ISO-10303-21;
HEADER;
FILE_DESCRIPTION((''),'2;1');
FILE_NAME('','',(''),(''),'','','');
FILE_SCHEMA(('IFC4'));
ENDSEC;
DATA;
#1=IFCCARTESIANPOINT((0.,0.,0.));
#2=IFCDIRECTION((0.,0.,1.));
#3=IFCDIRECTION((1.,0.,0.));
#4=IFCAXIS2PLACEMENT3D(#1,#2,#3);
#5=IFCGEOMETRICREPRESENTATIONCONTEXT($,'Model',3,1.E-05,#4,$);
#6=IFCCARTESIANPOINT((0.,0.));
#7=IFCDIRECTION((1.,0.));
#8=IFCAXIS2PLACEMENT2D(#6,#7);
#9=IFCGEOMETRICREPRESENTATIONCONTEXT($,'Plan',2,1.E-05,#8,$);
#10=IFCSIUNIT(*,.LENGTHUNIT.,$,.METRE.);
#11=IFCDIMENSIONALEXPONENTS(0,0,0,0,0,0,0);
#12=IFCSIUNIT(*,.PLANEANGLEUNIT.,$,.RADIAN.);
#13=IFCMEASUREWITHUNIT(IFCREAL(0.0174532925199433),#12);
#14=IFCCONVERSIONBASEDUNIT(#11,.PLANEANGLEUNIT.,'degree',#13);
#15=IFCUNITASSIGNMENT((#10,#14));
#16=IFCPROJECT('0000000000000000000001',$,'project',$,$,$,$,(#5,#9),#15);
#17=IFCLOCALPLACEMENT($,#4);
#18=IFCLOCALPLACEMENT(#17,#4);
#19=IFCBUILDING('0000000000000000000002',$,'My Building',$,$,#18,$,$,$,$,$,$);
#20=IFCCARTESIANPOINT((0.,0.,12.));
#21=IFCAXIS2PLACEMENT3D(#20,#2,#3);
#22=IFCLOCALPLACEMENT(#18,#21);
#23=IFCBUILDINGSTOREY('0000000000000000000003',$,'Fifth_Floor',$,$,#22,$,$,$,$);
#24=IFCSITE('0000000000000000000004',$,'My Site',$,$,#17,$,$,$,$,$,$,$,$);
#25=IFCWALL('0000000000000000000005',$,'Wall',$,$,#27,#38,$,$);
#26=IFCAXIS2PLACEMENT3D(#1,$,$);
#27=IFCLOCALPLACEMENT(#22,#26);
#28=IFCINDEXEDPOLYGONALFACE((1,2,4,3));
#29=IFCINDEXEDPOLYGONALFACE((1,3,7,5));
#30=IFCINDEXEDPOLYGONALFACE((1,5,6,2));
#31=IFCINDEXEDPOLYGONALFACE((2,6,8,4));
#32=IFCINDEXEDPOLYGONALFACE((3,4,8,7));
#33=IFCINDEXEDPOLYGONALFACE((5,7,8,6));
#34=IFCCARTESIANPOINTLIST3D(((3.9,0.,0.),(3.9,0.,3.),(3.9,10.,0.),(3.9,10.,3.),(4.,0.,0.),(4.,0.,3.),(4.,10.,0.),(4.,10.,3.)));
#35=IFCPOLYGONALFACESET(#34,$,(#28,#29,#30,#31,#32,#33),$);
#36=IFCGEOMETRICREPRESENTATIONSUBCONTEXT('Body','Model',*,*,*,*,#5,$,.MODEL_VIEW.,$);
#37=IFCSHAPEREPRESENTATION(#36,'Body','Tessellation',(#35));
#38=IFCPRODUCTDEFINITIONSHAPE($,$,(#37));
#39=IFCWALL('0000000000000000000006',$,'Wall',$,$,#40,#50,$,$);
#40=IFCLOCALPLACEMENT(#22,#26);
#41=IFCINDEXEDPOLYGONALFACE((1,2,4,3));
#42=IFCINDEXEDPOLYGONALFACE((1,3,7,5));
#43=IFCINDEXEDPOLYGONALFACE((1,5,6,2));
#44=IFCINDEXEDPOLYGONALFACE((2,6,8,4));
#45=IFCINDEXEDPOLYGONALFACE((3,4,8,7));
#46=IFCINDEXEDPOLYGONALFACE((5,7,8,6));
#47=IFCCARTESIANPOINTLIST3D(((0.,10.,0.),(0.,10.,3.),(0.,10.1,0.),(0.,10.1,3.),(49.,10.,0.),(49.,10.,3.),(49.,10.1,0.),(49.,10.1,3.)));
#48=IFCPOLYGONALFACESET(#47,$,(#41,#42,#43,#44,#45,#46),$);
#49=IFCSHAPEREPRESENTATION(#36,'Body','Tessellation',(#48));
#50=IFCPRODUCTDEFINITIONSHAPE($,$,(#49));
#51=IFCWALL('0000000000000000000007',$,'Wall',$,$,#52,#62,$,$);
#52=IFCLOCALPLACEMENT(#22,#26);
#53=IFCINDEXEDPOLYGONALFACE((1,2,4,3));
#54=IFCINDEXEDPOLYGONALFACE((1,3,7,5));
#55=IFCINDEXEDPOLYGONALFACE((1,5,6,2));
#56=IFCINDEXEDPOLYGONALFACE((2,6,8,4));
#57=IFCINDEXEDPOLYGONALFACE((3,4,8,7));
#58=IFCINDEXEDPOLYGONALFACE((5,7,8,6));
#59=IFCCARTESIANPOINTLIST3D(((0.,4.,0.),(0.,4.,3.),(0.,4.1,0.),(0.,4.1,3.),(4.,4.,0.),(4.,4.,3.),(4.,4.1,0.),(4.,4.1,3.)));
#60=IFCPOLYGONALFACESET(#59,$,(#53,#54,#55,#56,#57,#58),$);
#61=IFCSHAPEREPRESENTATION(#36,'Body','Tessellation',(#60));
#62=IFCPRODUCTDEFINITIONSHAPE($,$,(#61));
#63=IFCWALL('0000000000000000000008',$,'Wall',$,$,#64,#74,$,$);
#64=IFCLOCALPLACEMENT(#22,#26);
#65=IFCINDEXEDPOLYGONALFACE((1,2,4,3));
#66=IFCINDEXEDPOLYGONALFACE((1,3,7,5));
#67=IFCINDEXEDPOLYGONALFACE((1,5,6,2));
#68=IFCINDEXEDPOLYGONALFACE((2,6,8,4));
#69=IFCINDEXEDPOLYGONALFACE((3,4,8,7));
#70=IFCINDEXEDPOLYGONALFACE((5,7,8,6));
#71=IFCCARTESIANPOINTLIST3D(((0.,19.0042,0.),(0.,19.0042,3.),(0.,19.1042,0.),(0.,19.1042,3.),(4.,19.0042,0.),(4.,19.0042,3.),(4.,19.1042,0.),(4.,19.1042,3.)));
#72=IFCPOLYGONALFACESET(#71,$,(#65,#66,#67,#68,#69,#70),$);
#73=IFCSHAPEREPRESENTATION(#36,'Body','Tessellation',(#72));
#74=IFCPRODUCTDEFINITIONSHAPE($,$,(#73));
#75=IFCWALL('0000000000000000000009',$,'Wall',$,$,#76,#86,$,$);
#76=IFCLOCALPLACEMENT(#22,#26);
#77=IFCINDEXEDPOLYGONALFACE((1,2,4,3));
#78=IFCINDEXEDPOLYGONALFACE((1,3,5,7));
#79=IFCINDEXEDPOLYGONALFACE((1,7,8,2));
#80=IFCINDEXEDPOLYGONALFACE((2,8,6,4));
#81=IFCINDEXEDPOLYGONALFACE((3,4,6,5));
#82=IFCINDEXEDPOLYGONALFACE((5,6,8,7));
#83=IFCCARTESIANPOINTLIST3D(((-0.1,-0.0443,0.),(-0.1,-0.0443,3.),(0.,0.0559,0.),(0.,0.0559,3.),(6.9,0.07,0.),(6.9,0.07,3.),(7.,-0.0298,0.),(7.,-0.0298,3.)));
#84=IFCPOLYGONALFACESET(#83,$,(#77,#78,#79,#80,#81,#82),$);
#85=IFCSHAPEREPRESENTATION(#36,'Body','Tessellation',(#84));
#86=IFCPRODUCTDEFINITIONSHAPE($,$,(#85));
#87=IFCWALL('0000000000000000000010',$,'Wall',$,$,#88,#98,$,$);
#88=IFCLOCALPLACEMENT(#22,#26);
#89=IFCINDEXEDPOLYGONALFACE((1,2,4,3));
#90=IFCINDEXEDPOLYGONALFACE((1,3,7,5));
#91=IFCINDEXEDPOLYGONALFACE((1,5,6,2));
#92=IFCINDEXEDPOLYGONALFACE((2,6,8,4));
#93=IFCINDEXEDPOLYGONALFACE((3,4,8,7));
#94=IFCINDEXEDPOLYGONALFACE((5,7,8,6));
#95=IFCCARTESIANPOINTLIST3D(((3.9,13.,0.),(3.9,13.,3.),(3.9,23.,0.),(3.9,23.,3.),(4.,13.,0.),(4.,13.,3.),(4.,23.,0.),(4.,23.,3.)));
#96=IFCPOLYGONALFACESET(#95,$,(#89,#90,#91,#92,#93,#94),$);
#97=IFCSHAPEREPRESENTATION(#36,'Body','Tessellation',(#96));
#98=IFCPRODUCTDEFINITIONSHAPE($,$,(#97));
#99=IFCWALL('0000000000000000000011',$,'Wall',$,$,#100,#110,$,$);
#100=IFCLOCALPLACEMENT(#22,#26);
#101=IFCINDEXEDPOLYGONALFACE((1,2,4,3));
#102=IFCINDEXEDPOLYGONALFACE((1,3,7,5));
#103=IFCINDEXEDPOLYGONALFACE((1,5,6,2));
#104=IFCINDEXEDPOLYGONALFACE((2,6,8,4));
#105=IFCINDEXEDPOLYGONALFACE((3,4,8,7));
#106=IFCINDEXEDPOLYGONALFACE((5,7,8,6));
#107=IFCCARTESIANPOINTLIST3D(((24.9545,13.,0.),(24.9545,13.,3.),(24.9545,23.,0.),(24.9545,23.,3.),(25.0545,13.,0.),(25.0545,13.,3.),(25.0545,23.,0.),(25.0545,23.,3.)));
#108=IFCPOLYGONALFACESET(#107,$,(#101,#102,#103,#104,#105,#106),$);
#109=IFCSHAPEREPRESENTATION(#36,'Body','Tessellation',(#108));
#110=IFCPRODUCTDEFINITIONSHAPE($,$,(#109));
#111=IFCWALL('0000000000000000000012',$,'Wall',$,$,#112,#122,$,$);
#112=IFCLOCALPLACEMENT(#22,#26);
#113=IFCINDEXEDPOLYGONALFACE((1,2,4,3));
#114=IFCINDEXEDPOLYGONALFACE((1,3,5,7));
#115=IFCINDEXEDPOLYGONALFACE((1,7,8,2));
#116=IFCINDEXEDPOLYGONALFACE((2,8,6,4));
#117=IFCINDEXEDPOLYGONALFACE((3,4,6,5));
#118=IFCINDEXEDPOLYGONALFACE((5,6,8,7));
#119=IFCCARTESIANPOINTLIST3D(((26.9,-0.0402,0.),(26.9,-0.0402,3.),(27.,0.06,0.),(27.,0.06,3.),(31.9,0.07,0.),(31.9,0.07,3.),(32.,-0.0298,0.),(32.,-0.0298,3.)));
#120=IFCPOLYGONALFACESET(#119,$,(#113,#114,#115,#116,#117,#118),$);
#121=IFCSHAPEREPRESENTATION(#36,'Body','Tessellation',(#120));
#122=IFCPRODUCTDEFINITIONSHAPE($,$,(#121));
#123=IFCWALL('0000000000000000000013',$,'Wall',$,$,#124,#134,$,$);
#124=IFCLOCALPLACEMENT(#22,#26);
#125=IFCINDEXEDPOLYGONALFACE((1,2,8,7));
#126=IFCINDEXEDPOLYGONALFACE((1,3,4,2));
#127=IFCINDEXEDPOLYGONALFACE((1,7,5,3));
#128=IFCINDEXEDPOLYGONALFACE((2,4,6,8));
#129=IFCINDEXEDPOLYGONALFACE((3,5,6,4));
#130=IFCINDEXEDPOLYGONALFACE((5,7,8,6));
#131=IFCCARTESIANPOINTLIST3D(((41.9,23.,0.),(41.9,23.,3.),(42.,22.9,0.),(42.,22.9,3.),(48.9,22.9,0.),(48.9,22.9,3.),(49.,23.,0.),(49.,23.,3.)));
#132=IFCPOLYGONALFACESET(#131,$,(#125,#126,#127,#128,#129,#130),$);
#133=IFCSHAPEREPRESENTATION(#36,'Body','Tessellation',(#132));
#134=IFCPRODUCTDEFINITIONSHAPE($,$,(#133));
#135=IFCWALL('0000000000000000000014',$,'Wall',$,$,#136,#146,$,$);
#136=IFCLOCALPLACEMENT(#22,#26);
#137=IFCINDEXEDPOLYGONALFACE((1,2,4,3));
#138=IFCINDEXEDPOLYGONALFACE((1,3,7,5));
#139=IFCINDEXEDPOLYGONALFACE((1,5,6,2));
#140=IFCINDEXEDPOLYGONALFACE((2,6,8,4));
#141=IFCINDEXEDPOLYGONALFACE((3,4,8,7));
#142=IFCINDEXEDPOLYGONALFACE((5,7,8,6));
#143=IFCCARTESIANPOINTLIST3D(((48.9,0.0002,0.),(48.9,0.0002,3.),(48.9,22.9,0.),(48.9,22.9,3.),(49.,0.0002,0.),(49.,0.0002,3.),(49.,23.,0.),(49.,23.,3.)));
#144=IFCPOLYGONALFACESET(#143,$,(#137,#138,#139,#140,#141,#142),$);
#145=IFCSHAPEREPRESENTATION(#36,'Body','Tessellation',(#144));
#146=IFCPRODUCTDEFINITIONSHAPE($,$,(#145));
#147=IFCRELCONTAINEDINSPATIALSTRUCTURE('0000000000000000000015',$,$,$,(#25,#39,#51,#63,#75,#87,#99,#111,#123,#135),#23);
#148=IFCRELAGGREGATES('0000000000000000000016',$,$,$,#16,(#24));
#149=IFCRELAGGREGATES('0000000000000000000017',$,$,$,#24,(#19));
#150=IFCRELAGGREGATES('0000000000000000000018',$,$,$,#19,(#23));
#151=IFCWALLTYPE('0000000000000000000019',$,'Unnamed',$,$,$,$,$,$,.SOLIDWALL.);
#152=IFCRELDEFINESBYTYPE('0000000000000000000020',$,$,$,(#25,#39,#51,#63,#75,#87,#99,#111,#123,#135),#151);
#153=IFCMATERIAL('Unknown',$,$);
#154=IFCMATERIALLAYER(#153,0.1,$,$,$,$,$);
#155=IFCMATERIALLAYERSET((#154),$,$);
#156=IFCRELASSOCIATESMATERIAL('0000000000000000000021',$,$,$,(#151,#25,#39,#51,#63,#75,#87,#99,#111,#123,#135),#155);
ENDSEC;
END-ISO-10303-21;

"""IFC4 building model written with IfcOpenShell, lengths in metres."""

from ifc_helpers import new_model, entity, si_unit, converted_unit, frame, origin_with_axes, origin_2d_with_axis, place, context, subcontext, project, spatial, line, indexed_curve, outline, extrude, material, layer, layer_set, layer_usage, type_object, element, save


model = new_model("IFC4")

# Units and contexts
model_context = context("Model", 3, precision=1e-05, world=origin_with_axes())
plan_context = context("Plan", 2, precision=1e-05, world=origin_2d_with_axis())
body_context = subcontext(model_context, "Body", "Model", "MODEL_VIEW")
ifc_project = project(units=[si_unit("LENGTHUNIT", "METRE"), converted_unit("PLANEANGLEUNIT", "degree", entity("IfcReal", 0.0174532925199433), si_unit("PLANEANGLEUNIT", "RADIAN"), dimensions=[0, 0, 0, 0, 0, 0, 0])], contexts=[model_context, plan_context])

# Site, building, storey
site_placement = place(None, origin_with_axes())
site = spatial("IfcSite", under=ifc_project, at=site_placement, Name="My Site")
building_placement = place(site_placement, origin_with_axes())
building = spatial("IfcBuilding", under=site, at=building_placement, Name="My Building")
storey_placement = place(building_placement, frame((0.0, 0.0, 12.0), z_axis=(0.0, 0.0, 1.0), x_axis=(1.0, 0.0, 0.0)))
storey = spatial("IfcBuildingStorey", under=building, at=storey_placement, Name="Fifth_Floor")

# Shared definitions
ifc_material = material(Name="Unknown")

# Walls
ifc_layer_1 = layer(ifc_material, 0.1)
ifc_layer_set_1 = layer_set([ifc_layer_1])
wall_type = type_object("IfcWallType", Name="Unnamed", PredefinedType="SOLIDWALL", material=ifc_layer_set_1)
ifc_layer_usage_1 = layer_usage(ifc_layer_set_1, "AXIS2", "POSITIVE", 0.0)
wall_1_placement = place(storey_placement, frame((3.9, 10.0, 0.0), z_axis=(0.0, 0.0, 1.0), x_axis=(0.0, -1.0, 0.0)))
element("IfcWall", 1, at=wall_1_placement, inside=storey, type_object=wall_type, material=ifc_layer_usage_1, Name="Wall", context=body_context, shape_type="SweptSolid", body=[
    extrude(outline(indexed_curve([(0.0, 0.0), (0.0, 0.1), (10.0, 0.1), (10.0, 0.0)], segments=[line(1, 2, 3, 4, 1)])), origin_with_axes(), (0.0, 0.0, 1.0), 3.0),
])
ifc_layer_usage_2 = layer_usage(ifc_layer_set_1, "AXIS2", "POSITIVE", 0.0)
wall_2_placement = place(storey_placement, frame((0.0, 10.0, 0.0), z_axis=(0.0, 0.0, 1.0), x_axis=(1.0, 0.0, 0.0)))
element("IfcWall", 2, at=wall_2_placement, inside=storey, type_object=wall_type, material=ifc_layer_usage_2, Name="Wall", context=body_context, shape_type="SweptSolid", body=[
    extrude(outline(indexed_curve([(0.0, 0.0), (0.0, 0.1), (49.0, 0.1), (49.0, 0.0)], segments=[line(1, 2, 3, 4, 1)])), origin_with_axes(), (0.0, 0.0, 1.0), 3.0),
])
ifc_layer_usage_3 = layer_usage(ifc_layer_set_1, "AXIS2", "POSITIVE", 0.0)
wall_3_placement = place(storey_placement, frame((0.0, 4.0, 0.0), z_axis=(0.0, 0.0, 1.0), x_axis=(1.0, 0.0, 0.0)))
element("IfcWall", 3, at=wall_3_placement, inside=storey, type_object=wall_type, material=ifc_layer_usage_3, Name="Wall", context=body_context, shape_type="SweptSolid", body=[
    extrude(outline(indexed_curve([(0.0, 0.0), (0.0, 0.1), (4.0, 0.1), (4.0, 0.0)], segments=[line(1, 2, 3, 4, 1)])), origin_with_axes(), (0.0, 0.0, 1.0), 3.0),
])
ifc_layer_usage_4 = layer_usage(ifc_layer_set_1, "AXIS2", "POSITIVE", 0.0)
wall_4_placement = place(storey_placement, frame((0.0, 19.0042, 0.0), z_axis=(0.0, 0.0, 1.0), x_axis=(1.0, 0.0, 0.0)))
element("IfcWall", 4, at=wall_4_placement, inside=storey, type_object=wall_type, material=ifc_layer_usage_4, Name="Wall", context=body_context, shape_type="SweptSolid", body=[
    extrude(outline(indexed_curve([(0.0, 0.0), (0.0, 0.1), (4.0, 0.1), (4.0, 0.0)], segments=[line(1, 2, 3, 4, 1)])), origin_with_axes(), (0.0, 0.0, 1.0), 3.0),
])
ifc_layer_usage_5 = layer_usage(ifc_layer_set_1, "AXIS2", "POSITIVE", 0.0)
wall_5_placement = place(storey_placement, frame((6.9, 0.07, 0.0), z_axis=(0.0, 0.0, 1.0), x_axis=(-0.999998, -0.002045, 0.0)))
element("IfcWall", 5, at=wall_5_placement, inside=storey, type_object=wall_type, material=ifc_layer_usage_5, Name="Wall", context=body_context, shape_type="SweptSolid", body=[
    extrude(outline(indexed_curve([(0.0, 0.0), (-0.0998, 0.1), (7.0002, 0.1), (6.9, 0.0)], segments=[line(1, 2, 3, 4, 1)])), origin_with_axes(), (0.0, 0.0, 1.0), 3.0),
])
ifc_layer_usage_6 = layer_usage(ifc_layer_set_1, "AXIS2", "POSITIVE", 0.0)
wall_6_placement = place(storey_placement, frame((3.9, 23.0, 0.0), z_axis=(0.0, 0.0, 1.0), x_axis=(0.0, -1.0, 0.0)))
element("IfcWall", 6, at=wall_6_placement, inside=storey, type_object=wall_type, material=ifc_layer_usage_6, Name="Wall", context=body_context, shape_type="SweptSolid", body=[
    extrude(outline(indexed_curve([(0.0, 0.0), (0.0, 0.1), (10.0, 0.1), (10.0, 0.0)], segments=[line(1, 2, 3, 4, 1)])), origin_with_axes(), (0.0, 0.0, 1.0), 3.0),
])
ifc_layer_usage_7 = layer_usage(ifc_layer_set_1, "AXIS2", "POSITIVE", 0.0)
wall_7_placement = place(storey_placement, frame((24.9545, 23.0, 0.0), z_axis=(0.0, 0.0, 1.0), x_axis=(0.0, -1.0, 0.0)))
element("IfcWall", 7, at=wall_7_placement, inside=storey, type_object=wall_type, material=ifc_layer_usage_7, Name="Wall", context=body_context, shape_type="SweptSolid", body=[
    extrude(outline(indexed_curve([(0.0, 0.0), (0.0, 0.1), (10.0, 0.1), (10.0, 0.0)], segments=[line(1, 2, 3, 4, 1)])), origin_with_axes(), (0.0, 0.0, 1.0), 3.0),
])
ifc_layer_usage_8 = layer_usage(ifc_layer_set_1, "AXIS2", "POSITIVE", 0.0)
wall_8_placement = place(storey_placement, frame((31.9, 0.07, 0.0), z_axis=(0.0, 0.0, 1.0), x_axis=(-0.999998, -0.002045, 0.0)))
element("IfcWall", 8, at=wall_8_placement, inside=storey, type_object=wall_type, material=ifc_layer_usage_8, Name="Wall", context=body_context, shape_type="SweptSolid", body=[
    extrude(outline(indexed_curve([(0.0, 0.0), (-0.0998, 0.1), (5.0002, 0.1), (4.9, 0.0)], segments=[line(1, 2, 3, 4, 1)])), origin_with_axes(), (0.0, 0.0, 1.0), 3.0),
])
ifc_layer_usage_9 = layer_usage(ifc_layer_set_1, "AXIS2", "POSITIVE", 0.0)
wall_9_placement = place(storey_placement, frame((41.9, 22.9, 0.0), z_axis=(0.0, 0.0, 1.0), x_axis=(1.0, 0.0, 0.0)))
element("IfcWall", 9, at=wall_9_placement, inside=storey, type_object=wall_type, material=ifc_layer_usage_9, Name="Wall", context=body_context, shape_type="SweptSolid", body=[
    extrude(outline(indexed_curve([(0.1, 0.0), (0.0, 0.1), (7.1, 0.1), (7.0, 0.0)], segments=[line(1, 2, 3, 4, 1)])), origin_with_axes(), (0.0, 0.0, 1.0), 3.0),
])
ifc_layer_usage_10 = layer_usage(ifc_layer_set_1, "AXIS2", "POSITIVE", 0.0)
wall_10_placement = place(storey_placement, frame((49.0, 0.0002, 0.0), z_axis=(0.0, 0.0, 1.0), x_axis=(0.0, 1.0, 0.0)))
element("IfcWall", 10, at=wall_10_placement, inside=storey, type_object=wall_type, material=ifc_layer_usage_10, Name="Wall", context=body_context, shape_type="SweptSolid", body=[
    extrude(outline(indexed_curve([(0.0, 0.0), (0.0, 0.1), (22.8998, 0.1), (22.9998, 0.0)], segments=[line(1, 2, 3, 4, 1)])), origin_with_axes(), (0.0, 0.0, 1.0), 3.0),
])

save(model, "model.ifc")
